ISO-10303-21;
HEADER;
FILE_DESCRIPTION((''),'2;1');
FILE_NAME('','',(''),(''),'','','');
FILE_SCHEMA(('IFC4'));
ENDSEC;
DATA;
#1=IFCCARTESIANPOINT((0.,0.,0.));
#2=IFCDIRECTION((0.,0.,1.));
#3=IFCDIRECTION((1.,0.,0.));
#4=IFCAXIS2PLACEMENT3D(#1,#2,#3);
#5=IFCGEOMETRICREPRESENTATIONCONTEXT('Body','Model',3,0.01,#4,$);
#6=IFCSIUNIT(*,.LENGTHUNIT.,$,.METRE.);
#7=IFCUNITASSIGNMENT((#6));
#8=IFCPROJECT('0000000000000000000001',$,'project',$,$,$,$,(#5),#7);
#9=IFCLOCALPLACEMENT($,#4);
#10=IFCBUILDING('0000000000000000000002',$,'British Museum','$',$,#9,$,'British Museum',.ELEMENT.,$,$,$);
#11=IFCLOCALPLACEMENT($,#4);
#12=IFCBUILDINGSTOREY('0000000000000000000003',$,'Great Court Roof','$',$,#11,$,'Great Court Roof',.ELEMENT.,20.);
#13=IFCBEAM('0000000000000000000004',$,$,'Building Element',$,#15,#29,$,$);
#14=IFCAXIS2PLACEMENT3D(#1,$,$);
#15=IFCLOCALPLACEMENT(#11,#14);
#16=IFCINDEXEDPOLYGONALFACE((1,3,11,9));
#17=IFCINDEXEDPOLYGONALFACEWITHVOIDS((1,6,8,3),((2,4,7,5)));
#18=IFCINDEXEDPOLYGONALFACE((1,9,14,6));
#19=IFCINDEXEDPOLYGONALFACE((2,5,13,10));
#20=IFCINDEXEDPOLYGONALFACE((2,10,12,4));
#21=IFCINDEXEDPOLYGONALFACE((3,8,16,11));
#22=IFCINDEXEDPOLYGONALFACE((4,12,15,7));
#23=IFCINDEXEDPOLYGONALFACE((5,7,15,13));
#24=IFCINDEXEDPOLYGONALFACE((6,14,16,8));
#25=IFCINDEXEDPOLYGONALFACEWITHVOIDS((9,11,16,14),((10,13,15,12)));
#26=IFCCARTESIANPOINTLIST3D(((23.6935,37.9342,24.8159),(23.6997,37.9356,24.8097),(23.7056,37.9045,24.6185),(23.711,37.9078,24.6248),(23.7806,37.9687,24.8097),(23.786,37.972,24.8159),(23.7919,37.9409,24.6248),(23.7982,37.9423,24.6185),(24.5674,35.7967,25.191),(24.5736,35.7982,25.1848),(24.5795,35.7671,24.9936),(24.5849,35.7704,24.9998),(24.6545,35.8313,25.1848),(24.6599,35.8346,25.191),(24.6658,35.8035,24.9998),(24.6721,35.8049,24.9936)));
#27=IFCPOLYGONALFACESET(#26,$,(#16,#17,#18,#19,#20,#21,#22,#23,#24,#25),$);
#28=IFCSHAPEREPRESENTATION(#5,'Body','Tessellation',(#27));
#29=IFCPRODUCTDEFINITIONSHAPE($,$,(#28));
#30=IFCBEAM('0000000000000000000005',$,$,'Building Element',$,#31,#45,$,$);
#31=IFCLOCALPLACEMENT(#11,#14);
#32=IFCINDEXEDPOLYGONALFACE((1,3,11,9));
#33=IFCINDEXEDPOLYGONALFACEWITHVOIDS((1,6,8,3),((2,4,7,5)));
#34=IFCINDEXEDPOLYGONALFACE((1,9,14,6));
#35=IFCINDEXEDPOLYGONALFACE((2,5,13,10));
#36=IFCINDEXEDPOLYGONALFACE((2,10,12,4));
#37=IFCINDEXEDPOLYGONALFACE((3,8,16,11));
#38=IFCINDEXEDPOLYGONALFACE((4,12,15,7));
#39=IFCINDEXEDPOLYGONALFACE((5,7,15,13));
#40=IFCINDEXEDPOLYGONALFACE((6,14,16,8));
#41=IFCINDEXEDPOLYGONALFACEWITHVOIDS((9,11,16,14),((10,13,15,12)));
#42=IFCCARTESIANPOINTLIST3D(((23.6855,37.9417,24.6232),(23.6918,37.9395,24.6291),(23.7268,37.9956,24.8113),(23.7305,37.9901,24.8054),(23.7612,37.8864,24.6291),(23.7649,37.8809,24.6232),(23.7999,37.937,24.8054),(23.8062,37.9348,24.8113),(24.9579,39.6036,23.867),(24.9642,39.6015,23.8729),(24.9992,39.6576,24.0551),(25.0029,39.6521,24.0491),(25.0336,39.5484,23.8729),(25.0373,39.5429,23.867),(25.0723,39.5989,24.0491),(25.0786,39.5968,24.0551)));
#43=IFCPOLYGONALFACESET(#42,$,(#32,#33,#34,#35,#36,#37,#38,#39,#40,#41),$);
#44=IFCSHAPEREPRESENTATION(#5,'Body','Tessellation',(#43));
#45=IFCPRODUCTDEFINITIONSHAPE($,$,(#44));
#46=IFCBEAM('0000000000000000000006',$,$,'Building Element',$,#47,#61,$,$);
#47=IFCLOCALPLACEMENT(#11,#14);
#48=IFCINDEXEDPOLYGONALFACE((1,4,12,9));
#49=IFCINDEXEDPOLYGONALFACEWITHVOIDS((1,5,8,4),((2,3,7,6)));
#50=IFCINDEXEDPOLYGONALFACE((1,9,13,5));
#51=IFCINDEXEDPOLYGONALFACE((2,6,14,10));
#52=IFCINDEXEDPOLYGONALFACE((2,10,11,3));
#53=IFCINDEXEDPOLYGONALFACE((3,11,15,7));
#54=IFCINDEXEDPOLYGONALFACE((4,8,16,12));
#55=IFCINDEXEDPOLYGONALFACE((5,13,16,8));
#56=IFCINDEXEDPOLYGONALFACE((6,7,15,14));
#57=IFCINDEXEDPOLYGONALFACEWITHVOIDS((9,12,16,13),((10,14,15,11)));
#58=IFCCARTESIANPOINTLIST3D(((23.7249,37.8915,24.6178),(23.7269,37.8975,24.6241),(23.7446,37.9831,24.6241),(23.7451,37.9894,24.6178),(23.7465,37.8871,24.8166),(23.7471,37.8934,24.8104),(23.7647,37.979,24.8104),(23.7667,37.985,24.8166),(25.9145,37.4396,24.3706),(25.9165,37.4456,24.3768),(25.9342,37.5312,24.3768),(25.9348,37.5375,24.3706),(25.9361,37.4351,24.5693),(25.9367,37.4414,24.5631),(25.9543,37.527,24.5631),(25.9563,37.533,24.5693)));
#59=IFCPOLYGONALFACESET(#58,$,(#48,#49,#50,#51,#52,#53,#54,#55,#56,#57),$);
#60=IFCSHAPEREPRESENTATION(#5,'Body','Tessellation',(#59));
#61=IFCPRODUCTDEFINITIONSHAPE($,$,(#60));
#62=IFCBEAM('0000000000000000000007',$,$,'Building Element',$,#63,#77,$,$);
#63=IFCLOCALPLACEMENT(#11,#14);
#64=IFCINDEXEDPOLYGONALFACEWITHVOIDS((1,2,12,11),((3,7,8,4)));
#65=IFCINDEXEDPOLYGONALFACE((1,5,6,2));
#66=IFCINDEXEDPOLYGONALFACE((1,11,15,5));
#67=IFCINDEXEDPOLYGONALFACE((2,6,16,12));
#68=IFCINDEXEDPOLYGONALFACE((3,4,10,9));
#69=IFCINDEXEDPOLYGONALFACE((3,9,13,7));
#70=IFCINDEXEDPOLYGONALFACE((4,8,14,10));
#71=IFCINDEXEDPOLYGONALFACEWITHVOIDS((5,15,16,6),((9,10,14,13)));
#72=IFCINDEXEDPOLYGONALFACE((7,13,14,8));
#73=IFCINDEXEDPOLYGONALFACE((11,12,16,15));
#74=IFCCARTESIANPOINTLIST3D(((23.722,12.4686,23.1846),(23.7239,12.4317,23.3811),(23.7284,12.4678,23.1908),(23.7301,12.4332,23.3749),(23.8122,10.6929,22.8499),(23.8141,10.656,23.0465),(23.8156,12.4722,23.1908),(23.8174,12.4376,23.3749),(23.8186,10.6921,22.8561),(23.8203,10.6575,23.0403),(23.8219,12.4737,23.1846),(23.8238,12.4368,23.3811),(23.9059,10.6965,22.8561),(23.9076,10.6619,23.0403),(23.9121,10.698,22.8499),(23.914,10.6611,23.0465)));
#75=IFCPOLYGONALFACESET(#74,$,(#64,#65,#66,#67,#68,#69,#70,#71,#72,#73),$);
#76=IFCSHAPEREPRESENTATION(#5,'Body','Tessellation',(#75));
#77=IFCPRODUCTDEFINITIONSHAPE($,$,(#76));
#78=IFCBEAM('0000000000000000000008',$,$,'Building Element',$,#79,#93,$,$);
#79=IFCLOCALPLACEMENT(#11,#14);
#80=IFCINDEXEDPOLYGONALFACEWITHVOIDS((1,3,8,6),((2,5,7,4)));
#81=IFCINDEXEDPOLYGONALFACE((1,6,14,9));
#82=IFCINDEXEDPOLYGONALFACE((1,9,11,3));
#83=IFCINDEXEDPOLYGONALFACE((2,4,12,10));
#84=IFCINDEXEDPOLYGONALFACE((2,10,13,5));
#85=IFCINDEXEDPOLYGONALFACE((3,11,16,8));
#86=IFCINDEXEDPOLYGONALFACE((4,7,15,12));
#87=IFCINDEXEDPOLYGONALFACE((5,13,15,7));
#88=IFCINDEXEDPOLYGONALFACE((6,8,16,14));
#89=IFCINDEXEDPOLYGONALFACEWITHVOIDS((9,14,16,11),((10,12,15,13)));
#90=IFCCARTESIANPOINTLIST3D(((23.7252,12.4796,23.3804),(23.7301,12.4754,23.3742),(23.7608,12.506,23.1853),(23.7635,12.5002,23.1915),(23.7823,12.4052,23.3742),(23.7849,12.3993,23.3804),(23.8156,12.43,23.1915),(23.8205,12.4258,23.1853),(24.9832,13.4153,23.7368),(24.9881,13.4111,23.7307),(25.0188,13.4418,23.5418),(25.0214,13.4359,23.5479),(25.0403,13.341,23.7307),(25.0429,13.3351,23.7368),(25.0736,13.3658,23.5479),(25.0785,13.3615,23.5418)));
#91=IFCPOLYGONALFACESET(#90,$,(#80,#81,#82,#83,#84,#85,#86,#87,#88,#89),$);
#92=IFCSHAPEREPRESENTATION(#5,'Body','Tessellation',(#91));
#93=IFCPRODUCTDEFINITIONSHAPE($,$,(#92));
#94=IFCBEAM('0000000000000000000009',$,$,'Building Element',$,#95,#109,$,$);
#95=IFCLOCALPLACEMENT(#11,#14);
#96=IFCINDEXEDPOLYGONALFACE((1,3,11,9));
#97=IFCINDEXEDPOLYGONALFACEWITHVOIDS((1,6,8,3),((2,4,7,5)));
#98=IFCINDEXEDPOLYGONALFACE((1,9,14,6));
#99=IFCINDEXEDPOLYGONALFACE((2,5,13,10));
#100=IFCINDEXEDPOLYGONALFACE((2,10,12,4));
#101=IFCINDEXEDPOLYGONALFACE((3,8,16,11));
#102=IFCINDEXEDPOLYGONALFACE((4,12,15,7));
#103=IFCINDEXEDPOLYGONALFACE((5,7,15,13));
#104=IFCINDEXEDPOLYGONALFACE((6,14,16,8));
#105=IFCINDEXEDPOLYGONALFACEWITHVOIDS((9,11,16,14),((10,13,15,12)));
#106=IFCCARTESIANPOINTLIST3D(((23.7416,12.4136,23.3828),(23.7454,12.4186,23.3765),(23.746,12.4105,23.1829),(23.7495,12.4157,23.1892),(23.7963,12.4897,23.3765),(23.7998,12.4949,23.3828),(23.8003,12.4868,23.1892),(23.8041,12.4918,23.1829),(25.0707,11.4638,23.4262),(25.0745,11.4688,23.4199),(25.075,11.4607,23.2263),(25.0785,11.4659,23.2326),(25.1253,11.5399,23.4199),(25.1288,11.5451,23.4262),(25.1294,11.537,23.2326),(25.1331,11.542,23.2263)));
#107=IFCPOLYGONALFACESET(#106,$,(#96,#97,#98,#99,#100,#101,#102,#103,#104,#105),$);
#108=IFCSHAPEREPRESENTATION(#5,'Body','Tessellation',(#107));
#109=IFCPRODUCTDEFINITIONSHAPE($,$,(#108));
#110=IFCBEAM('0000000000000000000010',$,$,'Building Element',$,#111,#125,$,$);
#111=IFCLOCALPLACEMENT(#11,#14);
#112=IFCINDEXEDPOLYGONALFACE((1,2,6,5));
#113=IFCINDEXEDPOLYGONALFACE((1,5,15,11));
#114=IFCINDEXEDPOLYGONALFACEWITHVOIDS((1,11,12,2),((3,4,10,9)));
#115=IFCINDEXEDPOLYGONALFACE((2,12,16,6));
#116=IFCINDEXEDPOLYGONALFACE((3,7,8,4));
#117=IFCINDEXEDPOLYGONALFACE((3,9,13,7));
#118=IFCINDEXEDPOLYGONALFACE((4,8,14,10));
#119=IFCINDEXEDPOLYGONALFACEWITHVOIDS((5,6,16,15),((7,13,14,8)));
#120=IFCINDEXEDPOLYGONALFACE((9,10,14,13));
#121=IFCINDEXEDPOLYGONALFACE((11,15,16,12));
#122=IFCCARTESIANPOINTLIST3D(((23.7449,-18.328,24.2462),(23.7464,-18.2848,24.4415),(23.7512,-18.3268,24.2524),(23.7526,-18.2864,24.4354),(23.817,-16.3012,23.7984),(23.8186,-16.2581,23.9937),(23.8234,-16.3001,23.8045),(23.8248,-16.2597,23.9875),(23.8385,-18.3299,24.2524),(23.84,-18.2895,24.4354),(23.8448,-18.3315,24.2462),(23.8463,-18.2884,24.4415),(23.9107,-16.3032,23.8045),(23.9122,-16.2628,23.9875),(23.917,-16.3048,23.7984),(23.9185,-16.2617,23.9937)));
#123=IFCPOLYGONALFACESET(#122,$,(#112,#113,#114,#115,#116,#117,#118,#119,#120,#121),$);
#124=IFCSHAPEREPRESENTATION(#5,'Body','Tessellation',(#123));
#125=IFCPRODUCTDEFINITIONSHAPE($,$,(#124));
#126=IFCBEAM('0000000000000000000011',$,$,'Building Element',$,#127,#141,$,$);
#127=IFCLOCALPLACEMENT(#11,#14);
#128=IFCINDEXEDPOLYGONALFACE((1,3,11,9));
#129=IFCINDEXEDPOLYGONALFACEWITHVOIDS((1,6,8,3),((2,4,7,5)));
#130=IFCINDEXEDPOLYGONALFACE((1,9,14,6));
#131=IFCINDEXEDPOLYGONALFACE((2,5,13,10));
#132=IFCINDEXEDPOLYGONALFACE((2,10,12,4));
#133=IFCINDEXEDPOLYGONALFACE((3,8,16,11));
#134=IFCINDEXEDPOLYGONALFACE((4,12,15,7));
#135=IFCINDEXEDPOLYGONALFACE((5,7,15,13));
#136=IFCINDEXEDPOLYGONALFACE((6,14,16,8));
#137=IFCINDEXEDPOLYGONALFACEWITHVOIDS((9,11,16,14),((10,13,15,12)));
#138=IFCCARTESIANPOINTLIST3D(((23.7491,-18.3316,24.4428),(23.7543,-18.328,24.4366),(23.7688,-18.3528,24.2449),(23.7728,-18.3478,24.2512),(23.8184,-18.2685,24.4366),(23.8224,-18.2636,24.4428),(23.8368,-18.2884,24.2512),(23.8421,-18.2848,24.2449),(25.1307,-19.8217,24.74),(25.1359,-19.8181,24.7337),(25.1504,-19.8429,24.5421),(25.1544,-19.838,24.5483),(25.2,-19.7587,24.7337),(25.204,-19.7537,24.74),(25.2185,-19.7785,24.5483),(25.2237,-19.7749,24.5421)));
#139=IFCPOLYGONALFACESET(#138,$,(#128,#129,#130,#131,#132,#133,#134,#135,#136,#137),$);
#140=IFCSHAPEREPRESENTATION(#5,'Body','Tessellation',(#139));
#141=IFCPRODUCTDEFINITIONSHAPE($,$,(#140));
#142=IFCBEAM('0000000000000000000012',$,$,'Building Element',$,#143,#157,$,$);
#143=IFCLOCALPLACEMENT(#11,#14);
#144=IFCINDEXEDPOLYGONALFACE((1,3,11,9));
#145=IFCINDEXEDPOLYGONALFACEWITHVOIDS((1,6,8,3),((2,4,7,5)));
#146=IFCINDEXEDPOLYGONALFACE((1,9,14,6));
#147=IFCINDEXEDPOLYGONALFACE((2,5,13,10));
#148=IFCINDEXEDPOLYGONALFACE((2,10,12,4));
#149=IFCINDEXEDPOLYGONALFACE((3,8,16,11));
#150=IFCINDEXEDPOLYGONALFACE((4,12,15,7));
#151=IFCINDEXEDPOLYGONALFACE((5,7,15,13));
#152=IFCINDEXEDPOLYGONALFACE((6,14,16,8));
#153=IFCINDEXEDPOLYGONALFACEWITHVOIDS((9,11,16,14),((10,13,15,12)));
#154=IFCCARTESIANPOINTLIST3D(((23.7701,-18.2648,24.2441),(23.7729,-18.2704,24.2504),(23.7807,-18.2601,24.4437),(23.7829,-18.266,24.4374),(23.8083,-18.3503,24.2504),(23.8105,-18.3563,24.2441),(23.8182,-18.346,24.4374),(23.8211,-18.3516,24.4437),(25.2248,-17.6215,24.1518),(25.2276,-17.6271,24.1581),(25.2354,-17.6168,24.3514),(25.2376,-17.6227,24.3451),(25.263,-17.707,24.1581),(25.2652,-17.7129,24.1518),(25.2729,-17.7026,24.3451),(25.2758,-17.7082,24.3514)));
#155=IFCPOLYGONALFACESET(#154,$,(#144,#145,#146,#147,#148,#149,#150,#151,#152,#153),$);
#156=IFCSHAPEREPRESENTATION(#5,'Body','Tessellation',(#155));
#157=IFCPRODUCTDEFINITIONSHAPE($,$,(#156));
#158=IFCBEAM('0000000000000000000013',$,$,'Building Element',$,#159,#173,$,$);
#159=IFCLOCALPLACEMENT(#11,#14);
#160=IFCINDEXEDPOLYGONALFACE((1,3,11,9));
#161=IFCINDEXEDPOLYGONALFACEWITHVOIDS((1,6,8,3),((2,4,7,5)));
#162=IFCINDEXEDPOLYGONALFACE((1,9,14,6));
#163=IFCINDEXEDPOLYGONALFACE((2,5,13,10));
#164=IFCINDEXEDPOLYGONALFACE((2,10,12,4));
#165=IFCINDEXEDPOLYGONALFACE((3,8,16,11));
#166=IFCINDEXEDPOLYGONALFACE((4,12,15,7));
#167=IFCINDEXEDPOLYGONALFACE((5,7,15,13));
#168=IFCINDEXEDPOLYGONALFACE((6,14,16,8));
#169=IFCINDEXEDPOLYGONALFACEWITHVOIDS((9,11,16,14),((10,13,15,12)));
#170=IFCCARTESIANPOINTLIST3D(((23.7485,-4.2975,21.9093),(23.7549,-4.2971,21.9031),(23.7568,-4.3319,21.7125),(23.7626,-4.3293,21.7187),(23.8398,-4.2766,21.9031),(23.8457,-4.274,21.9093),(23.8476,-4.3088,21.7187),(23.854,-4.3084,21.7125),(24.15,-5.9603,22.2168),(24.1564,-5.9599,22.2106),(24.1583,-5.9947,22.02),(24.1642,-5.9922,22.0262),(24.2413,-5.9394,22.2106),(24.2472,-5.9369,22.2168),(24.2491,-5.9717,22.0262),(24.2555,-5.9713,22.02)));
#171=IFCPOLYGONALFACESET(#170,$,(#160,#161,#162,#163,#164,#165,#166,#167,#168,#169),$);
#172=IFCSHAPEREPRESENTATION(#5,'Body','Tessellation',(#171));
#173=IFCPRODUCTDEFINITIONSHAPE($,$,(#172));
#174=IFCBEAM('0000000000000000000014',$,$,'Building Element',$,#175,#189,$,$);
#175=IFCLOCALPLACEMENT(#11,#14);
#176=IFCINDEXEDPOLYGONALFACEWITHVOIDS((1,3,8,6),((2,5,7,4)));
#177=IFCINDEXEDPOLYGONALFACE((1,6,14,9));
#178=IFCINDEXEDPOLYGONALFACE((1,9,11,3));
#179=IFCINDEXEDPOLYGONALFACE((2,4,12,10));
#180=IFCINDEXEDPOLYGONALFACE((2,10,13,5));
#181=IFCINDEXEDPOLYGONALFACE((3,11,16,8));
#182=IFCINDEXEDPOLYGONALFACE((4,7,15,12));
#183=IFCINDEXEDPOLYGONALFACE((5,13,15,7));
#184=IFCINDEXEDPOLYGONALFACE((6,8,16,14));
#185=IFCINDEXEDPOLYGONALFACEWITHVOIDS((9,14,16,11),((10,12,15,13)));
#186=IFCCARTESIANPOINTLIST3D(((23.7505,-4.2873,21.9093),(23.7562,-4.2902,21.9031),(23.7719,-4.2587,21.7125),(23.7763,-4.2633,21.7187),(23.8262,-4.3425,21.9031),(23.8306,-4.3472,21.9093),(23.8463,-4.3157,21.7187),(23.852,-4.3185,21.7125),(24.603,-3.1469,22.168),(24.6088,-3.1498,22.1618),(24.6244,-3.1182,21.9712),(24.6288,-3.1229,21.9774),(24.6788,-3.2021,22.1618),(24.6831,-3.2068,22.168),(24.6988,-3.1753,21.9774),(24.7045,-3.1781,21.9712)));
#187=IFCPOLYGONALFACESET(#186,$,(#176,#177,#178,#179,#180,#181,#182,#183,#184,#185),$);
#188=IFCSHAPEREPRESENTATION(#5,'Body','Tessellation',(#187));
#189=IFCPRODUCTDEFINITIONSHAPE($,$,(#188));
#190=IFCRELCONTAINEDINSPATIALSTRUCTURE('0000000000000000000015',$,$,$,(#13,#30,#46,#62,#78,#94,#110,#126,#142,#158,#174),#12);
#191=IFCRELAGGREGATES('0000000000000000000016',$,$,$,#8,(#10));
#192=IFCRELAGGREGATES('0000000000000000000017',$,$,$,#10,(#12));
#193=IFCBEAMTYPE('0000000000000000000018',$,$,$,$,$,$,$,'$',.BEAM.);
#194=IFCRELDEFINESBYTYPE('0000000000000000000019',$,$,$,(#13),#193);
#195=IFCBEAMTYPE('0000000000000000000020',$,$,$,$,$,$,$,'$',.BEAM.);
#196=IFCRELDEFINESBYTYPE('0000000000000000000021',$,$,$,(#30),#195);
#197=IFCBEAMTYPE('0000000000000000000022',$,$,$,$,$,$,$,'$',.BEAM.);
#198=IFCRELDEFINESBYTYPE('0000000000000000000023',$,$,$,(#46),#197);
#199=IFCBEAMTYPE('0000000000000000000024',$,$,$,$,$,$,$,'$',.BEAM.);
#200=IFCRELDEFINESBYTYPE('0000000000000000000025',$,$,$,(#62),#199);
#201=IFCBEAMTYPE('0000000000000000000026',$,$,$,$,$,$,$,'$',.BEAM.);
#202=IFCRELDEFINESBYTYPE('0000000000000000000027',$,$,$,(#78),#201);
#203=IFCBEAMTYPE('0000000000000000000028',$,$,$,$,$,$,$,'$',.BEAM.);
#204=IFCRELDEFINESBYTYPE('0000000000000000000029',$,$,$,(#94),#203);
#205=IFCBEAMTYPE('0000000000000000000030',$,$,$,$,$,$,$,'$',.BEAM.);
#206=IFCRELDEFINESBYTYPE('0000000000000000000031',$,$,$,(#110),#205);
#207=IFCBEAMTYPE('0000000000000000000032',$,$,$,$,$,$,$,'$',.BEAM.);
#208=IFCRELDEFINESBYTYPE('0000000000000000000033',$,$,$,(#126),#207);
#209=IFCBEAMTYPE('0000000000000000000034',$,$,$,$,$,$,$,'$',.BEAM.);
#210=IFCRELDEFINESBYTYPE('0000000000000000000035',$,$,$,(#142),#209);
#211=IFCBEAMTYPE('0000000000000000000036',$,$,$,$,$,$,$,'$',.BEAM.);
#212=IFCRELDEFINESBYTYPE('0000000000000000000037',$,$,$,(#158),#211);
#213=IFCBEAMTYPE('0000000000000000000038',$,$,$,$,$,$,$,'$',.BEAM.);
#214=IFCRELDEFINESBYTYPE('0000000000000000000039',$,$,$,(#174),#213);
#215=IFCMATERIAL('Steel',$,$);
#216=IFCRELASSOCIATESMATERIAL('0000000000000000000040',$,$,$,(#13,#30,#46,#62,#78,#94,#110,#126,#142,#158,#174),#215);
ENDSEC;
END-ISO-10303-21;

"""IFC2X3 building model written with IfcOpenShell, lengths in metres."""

from ifc_helpers import new_model, si_unit, frame, origin_with_axes, origin_2d, place, context, project, spatial, hollow_rectangle, extrude, material, type_object, element, save


model = new_model("IFC2X3")

# Units and contexts
model_context = context("Model", 3, precision=0.01, world=origin_with_axes(), identifier="Body")
ifc_project = project(units=[si_unit("LENGTHUNIT", "METRE")], contexts=[model_context])

# Building, storey
building_placement = place(None, origin_with_axes())
building = spatial("IfcBuilding", under=ifc_project, at=building_placement, Name="British Museum", Description="$", LongName="British Museum", CompositionType="ELEMENT")
storey_placement = place(None, origin_with_axes())
storey = spatial("IfcBuildingStorey", under=building, at=storey_placement, Name="Great Court Roof", Description="$", LongName="Great Court Roof", CompositionType="ELEMENT", Elevation=20.0)

# Beams
ifc_material = material(Name="Steel")
beam_type_1 = type_object("IfcBeamType", ElementType="$", PredefinedType="BEAM")
beam_1_placement = place(None, origin_with_axes())
element("IfcBeam", 1, at=beam_1_placement, inside=storey, type_object=beam_type_1, material=ifc_material, Description="Building Element", context=model_context, shape_type="SweptSolid", body=[
    extrude(hollow_rectangle(XDim=0.1, YDim=0.2, WallThickness=0.0063, InnerFilletRadius=-0.0063, OuterFilletRadius=0.0, at=origin_2d()), frame((23.7458, 37.9383, 24.7172), z_axis=(0.373552, -0.913651, 0.160314), x_axis=(0.925623, 0.378447, 0.0)), (0.0, 0.0, 1.0), 2.3394),
])
beam_type_2 = type_object("IfcBeamType", ElementType="$", PredefinedType="BEAM")
beam_2_placement = place(None, origin_with_axes())
element("IfcBeam", 2, at=beam_2_placement, inside=storey, type_object=beam_type_2, material=ifc_material, Description="Building Element", context=model_context, shape_type="SweptSolid", body=[
    extrude(hollow_rectangle(XDim=0.1, YDim=0.2, WallThickness=0.0063, InnerFilletRadius=-0.0063, OuterFilletRadius=0.0, at=origin_2d()), frame((23.7458, 37.9383, 24.7172), z_axis=(0.571733, 0.746766, -0.339797), x_axis=(-0.794011, 0.607903, 0.0)), (0.0, 0.0, 1.0), 2.2256),
])
beam_type_3 = type_object("IfcBeamType", ElementType="$", PredefinedType="BEAM")
beam_3_placement = place(None, origin_with_axes())
element("IfcBeam", 3, at=beam_3_placement, inside=storey, type_object=beam_type_3, material=ifc_material, Description="Building Element", context=model_context, shape_type="SweptSolid", body=[
    extrude(hollow_rectangle(XDim=0.1, YDim=0.2, WallThickness=0.0063, InnerFilletRadius=-0.0063, OuterFilletRadius=0.0, at=origin_2d()), frame((23.7458, 37.9383, 24.7172), z_axis=(0.973419, -0.200923, -0.109933), x_axis=(0.202148, 0.979355, 0.0)), (0.0, 0.0, 1.0), 2.2494),
])
beam_type_4 = type_object("IfcBeamType", ElementType="$", PredefinedType="BEAM")
beam_4_placement = place(None, origin_with_axes())
element("IfcBeam", 4, at=beam_4_placement, inside=storey, type_object=beam_type_4, material=ifc_material, Description="Building Element", context=model_context, shape_type="SweptSolid", body=[
    extrude(hollow_rectangle(XDim=0.1, YDim=0.2, WallThickness=0.0063, InnerFilletRadius=-0.0063, OuterFilletRadius=0.0, at=origin_2d()), frame((23.7729, 12.4527, 23.2828), z_axis=(0.049867, -0.98148, -0.18496), x_axis=(0.998712, 0.050742, 0.0)), (0.0, 0.0, 1.0), 1.8092),
])
beam_type_5 = type_object("IfcBeamType", ElementType="$", PredefinedType="BEAM")
beam_5_placement = place(None, origin_with_axes())
element("IfcBeam", 5, at=beam_5_placement, inside=storey, type_object=beam_type_5, material=ifc_material, Description="Building Element", context=model_context, shape_type="SweptSolid", body=[
    extrude(hollow_rectangle(XDim=0.1, YDim=0.2, WallThickness=0.0063, InnerFilletRadius=-0.0063, OuterFilletRadius=0.0, at=origin_2d()), frame((23.7729, 12.4527, 23.2828), z_axis=(0.7824, 0.581977, 0.221705), x_axis=(-0.59683, 0.802368, 0.0)), (0.0, 0.0, 1.0), 1.6078),
])
beam_type_6 = type_object("IfcBeamType", ElementType="$", PredefinedType="BEAM")
beam_6_placement = place(None, origin_with_axes())
element("IfcBeam", 6, at=beam_6_placement, inside=storey, type_object=beam_type_6, material=ifc_material, Description="Building Element", context=model_context, shape_type="SweptSolid", body=[
    extrude(hollow_rectangle(XDim=0.1, YDim=0.2, WallThickness=0.0063, InnerFilletRadius=-0.0063, OuterFilletRadius=0.0, at=origin_2d()), frame((23.7729, 12.4527, 23.2828), z_axis=(0.81331, -0.581224, 0.026564), x_axis=(0.581429, 0.813597, 0.0)), (0.0, 0.0, 1.0), 1.6341),
])
beam_type_7 = type_object("IfcBeamType", ElementType="$", PredefinedType="BEAM")
beam_7_placement = place(None, origin_with_axes())
element("IfcBeam", 7, at=beam_7_placement, inside=storey, type_object=beam_type_7, material=ifc_material, Description="Building Element", context=model_context, shape_type="SweptSolid", body=[
    extrude(hollow_rectangle(XDim=0.1, YDim=0.2, WallThickness=0.0063, InnerFilletRadius=-0.0063, OuterFilletRadius=0.0, at=origin_2d()), frame((23.7956, -18.3082, 24.3439), z_axis=(0.034752, 0.975852, -0.215652), x_axis=(-0.999367, 0.035589, 0.0)), (0.0, 0.0, 1.0), 2.0769),
])
beam_type_8 = type_object("IfcBeamType", ElementType="$", PredefinedType="BEAM")
beam_8_placement = place(None, origin_with_axes())
element("IfcBeam", 8, at=beam_8_placement, inside=storey, type_object=beam_type_8, material=ifc_material, Description="Building Element", context=model_context, shape_type="SweptSolid", body=[
    extrude(hollow_rectangle(XDim=0.1, YDim=0.2, WallThickness=0.0063, InnerFilletRadius=-0.0063, OuterFilletRadius=0.0, at=origin_2d()), frame((23.7956, -18.3082, 24.3439), z_axis=(0.672748, -0.725589, 0.144676), x_axis=(0.733304, 0.679901, 0.0)), (0.0, 0.0, 1.0), 2.0537),
])
beam_type_9 = type_object("IfcBeamType", ElementType="$", PredefinedType="BEAM")
beam_9_placement = place(None, origin_with_axes())
element("IfcBeam", 9, at=beam_9_placement, inside=storey, type_object=beam_type_9, material=ifc_material, Description="Building Element", context=model_context, shape_type="SweptSolid", body=[
    extrude(hollow_rectangle(XDim=0.1, YDim=0.2, WallThickness=0.0063, InnerFilletRadius=-0.0063, OuterFilletRadius=0.0, at=origin_2d()), frame((23.7956, -18.3082, 24.3439), z_axis=(0.913021, 0.403778, -0.057925), x_axis=(-0.404457, 0.914557, 0.0)), (0.0, 0.0, 1.0), 1.5933),
])
beam_type_10 = type_object("IfcBeamType", ElementType="$", PredefinedType="BEAM")
beam_10_placement = place(None, origin_with_axes())
element("IfcBeam", 10, at=beam_10_placement, inside=storey, type_object=beam_type_10, material=ifc_material, Description="Building Element", context=model_context, shape_type="SweptSolid", body=[
    extrude(hollow_rectangle(XDim=0.1, YDim=0.2, WallThickness=0.0063, InnerFilletRadius=-0.0063, OuterFilletRadius=0.0, at=origin_2d()), frame((23.8012, -4.3029, 21.8109), z_axis=(0.231017, -0.956725, 0.176942), x_axis=(0.972063, 0.234721, 0.0)), (0.0, 0.0, 1.0), 1.7381),
])
beam_type_11 = type_object("IfcBeamType", ElementType="$", PredefinedType="BEAM")
beam_11_placement = place(None, origin_with_axes())
element("IfcBeam", 11, at=beam_11_placement, inside=storey, type_object=beam_type_11, material=ifc_material, Description="Building Element", context=model_context, shape_type="SweptSolid", body=[
    extrude(hollow_rectangle(XDim=0.1, YDim=0.2, WallThickness=0.0063, InnerFilletRadius=-0.0063, OuterFilletRadius=0.0, at=origin_2d()), frame((23.8012, -4.3029, 21.8109), z_axis=(0.589118, 0.788028, 0.178748), x_axis=(-0.800927, 0.598761, 0.0)), (0.0, 0.0, 1.0), 1.4472),
])

save(model, "model.ifc")
